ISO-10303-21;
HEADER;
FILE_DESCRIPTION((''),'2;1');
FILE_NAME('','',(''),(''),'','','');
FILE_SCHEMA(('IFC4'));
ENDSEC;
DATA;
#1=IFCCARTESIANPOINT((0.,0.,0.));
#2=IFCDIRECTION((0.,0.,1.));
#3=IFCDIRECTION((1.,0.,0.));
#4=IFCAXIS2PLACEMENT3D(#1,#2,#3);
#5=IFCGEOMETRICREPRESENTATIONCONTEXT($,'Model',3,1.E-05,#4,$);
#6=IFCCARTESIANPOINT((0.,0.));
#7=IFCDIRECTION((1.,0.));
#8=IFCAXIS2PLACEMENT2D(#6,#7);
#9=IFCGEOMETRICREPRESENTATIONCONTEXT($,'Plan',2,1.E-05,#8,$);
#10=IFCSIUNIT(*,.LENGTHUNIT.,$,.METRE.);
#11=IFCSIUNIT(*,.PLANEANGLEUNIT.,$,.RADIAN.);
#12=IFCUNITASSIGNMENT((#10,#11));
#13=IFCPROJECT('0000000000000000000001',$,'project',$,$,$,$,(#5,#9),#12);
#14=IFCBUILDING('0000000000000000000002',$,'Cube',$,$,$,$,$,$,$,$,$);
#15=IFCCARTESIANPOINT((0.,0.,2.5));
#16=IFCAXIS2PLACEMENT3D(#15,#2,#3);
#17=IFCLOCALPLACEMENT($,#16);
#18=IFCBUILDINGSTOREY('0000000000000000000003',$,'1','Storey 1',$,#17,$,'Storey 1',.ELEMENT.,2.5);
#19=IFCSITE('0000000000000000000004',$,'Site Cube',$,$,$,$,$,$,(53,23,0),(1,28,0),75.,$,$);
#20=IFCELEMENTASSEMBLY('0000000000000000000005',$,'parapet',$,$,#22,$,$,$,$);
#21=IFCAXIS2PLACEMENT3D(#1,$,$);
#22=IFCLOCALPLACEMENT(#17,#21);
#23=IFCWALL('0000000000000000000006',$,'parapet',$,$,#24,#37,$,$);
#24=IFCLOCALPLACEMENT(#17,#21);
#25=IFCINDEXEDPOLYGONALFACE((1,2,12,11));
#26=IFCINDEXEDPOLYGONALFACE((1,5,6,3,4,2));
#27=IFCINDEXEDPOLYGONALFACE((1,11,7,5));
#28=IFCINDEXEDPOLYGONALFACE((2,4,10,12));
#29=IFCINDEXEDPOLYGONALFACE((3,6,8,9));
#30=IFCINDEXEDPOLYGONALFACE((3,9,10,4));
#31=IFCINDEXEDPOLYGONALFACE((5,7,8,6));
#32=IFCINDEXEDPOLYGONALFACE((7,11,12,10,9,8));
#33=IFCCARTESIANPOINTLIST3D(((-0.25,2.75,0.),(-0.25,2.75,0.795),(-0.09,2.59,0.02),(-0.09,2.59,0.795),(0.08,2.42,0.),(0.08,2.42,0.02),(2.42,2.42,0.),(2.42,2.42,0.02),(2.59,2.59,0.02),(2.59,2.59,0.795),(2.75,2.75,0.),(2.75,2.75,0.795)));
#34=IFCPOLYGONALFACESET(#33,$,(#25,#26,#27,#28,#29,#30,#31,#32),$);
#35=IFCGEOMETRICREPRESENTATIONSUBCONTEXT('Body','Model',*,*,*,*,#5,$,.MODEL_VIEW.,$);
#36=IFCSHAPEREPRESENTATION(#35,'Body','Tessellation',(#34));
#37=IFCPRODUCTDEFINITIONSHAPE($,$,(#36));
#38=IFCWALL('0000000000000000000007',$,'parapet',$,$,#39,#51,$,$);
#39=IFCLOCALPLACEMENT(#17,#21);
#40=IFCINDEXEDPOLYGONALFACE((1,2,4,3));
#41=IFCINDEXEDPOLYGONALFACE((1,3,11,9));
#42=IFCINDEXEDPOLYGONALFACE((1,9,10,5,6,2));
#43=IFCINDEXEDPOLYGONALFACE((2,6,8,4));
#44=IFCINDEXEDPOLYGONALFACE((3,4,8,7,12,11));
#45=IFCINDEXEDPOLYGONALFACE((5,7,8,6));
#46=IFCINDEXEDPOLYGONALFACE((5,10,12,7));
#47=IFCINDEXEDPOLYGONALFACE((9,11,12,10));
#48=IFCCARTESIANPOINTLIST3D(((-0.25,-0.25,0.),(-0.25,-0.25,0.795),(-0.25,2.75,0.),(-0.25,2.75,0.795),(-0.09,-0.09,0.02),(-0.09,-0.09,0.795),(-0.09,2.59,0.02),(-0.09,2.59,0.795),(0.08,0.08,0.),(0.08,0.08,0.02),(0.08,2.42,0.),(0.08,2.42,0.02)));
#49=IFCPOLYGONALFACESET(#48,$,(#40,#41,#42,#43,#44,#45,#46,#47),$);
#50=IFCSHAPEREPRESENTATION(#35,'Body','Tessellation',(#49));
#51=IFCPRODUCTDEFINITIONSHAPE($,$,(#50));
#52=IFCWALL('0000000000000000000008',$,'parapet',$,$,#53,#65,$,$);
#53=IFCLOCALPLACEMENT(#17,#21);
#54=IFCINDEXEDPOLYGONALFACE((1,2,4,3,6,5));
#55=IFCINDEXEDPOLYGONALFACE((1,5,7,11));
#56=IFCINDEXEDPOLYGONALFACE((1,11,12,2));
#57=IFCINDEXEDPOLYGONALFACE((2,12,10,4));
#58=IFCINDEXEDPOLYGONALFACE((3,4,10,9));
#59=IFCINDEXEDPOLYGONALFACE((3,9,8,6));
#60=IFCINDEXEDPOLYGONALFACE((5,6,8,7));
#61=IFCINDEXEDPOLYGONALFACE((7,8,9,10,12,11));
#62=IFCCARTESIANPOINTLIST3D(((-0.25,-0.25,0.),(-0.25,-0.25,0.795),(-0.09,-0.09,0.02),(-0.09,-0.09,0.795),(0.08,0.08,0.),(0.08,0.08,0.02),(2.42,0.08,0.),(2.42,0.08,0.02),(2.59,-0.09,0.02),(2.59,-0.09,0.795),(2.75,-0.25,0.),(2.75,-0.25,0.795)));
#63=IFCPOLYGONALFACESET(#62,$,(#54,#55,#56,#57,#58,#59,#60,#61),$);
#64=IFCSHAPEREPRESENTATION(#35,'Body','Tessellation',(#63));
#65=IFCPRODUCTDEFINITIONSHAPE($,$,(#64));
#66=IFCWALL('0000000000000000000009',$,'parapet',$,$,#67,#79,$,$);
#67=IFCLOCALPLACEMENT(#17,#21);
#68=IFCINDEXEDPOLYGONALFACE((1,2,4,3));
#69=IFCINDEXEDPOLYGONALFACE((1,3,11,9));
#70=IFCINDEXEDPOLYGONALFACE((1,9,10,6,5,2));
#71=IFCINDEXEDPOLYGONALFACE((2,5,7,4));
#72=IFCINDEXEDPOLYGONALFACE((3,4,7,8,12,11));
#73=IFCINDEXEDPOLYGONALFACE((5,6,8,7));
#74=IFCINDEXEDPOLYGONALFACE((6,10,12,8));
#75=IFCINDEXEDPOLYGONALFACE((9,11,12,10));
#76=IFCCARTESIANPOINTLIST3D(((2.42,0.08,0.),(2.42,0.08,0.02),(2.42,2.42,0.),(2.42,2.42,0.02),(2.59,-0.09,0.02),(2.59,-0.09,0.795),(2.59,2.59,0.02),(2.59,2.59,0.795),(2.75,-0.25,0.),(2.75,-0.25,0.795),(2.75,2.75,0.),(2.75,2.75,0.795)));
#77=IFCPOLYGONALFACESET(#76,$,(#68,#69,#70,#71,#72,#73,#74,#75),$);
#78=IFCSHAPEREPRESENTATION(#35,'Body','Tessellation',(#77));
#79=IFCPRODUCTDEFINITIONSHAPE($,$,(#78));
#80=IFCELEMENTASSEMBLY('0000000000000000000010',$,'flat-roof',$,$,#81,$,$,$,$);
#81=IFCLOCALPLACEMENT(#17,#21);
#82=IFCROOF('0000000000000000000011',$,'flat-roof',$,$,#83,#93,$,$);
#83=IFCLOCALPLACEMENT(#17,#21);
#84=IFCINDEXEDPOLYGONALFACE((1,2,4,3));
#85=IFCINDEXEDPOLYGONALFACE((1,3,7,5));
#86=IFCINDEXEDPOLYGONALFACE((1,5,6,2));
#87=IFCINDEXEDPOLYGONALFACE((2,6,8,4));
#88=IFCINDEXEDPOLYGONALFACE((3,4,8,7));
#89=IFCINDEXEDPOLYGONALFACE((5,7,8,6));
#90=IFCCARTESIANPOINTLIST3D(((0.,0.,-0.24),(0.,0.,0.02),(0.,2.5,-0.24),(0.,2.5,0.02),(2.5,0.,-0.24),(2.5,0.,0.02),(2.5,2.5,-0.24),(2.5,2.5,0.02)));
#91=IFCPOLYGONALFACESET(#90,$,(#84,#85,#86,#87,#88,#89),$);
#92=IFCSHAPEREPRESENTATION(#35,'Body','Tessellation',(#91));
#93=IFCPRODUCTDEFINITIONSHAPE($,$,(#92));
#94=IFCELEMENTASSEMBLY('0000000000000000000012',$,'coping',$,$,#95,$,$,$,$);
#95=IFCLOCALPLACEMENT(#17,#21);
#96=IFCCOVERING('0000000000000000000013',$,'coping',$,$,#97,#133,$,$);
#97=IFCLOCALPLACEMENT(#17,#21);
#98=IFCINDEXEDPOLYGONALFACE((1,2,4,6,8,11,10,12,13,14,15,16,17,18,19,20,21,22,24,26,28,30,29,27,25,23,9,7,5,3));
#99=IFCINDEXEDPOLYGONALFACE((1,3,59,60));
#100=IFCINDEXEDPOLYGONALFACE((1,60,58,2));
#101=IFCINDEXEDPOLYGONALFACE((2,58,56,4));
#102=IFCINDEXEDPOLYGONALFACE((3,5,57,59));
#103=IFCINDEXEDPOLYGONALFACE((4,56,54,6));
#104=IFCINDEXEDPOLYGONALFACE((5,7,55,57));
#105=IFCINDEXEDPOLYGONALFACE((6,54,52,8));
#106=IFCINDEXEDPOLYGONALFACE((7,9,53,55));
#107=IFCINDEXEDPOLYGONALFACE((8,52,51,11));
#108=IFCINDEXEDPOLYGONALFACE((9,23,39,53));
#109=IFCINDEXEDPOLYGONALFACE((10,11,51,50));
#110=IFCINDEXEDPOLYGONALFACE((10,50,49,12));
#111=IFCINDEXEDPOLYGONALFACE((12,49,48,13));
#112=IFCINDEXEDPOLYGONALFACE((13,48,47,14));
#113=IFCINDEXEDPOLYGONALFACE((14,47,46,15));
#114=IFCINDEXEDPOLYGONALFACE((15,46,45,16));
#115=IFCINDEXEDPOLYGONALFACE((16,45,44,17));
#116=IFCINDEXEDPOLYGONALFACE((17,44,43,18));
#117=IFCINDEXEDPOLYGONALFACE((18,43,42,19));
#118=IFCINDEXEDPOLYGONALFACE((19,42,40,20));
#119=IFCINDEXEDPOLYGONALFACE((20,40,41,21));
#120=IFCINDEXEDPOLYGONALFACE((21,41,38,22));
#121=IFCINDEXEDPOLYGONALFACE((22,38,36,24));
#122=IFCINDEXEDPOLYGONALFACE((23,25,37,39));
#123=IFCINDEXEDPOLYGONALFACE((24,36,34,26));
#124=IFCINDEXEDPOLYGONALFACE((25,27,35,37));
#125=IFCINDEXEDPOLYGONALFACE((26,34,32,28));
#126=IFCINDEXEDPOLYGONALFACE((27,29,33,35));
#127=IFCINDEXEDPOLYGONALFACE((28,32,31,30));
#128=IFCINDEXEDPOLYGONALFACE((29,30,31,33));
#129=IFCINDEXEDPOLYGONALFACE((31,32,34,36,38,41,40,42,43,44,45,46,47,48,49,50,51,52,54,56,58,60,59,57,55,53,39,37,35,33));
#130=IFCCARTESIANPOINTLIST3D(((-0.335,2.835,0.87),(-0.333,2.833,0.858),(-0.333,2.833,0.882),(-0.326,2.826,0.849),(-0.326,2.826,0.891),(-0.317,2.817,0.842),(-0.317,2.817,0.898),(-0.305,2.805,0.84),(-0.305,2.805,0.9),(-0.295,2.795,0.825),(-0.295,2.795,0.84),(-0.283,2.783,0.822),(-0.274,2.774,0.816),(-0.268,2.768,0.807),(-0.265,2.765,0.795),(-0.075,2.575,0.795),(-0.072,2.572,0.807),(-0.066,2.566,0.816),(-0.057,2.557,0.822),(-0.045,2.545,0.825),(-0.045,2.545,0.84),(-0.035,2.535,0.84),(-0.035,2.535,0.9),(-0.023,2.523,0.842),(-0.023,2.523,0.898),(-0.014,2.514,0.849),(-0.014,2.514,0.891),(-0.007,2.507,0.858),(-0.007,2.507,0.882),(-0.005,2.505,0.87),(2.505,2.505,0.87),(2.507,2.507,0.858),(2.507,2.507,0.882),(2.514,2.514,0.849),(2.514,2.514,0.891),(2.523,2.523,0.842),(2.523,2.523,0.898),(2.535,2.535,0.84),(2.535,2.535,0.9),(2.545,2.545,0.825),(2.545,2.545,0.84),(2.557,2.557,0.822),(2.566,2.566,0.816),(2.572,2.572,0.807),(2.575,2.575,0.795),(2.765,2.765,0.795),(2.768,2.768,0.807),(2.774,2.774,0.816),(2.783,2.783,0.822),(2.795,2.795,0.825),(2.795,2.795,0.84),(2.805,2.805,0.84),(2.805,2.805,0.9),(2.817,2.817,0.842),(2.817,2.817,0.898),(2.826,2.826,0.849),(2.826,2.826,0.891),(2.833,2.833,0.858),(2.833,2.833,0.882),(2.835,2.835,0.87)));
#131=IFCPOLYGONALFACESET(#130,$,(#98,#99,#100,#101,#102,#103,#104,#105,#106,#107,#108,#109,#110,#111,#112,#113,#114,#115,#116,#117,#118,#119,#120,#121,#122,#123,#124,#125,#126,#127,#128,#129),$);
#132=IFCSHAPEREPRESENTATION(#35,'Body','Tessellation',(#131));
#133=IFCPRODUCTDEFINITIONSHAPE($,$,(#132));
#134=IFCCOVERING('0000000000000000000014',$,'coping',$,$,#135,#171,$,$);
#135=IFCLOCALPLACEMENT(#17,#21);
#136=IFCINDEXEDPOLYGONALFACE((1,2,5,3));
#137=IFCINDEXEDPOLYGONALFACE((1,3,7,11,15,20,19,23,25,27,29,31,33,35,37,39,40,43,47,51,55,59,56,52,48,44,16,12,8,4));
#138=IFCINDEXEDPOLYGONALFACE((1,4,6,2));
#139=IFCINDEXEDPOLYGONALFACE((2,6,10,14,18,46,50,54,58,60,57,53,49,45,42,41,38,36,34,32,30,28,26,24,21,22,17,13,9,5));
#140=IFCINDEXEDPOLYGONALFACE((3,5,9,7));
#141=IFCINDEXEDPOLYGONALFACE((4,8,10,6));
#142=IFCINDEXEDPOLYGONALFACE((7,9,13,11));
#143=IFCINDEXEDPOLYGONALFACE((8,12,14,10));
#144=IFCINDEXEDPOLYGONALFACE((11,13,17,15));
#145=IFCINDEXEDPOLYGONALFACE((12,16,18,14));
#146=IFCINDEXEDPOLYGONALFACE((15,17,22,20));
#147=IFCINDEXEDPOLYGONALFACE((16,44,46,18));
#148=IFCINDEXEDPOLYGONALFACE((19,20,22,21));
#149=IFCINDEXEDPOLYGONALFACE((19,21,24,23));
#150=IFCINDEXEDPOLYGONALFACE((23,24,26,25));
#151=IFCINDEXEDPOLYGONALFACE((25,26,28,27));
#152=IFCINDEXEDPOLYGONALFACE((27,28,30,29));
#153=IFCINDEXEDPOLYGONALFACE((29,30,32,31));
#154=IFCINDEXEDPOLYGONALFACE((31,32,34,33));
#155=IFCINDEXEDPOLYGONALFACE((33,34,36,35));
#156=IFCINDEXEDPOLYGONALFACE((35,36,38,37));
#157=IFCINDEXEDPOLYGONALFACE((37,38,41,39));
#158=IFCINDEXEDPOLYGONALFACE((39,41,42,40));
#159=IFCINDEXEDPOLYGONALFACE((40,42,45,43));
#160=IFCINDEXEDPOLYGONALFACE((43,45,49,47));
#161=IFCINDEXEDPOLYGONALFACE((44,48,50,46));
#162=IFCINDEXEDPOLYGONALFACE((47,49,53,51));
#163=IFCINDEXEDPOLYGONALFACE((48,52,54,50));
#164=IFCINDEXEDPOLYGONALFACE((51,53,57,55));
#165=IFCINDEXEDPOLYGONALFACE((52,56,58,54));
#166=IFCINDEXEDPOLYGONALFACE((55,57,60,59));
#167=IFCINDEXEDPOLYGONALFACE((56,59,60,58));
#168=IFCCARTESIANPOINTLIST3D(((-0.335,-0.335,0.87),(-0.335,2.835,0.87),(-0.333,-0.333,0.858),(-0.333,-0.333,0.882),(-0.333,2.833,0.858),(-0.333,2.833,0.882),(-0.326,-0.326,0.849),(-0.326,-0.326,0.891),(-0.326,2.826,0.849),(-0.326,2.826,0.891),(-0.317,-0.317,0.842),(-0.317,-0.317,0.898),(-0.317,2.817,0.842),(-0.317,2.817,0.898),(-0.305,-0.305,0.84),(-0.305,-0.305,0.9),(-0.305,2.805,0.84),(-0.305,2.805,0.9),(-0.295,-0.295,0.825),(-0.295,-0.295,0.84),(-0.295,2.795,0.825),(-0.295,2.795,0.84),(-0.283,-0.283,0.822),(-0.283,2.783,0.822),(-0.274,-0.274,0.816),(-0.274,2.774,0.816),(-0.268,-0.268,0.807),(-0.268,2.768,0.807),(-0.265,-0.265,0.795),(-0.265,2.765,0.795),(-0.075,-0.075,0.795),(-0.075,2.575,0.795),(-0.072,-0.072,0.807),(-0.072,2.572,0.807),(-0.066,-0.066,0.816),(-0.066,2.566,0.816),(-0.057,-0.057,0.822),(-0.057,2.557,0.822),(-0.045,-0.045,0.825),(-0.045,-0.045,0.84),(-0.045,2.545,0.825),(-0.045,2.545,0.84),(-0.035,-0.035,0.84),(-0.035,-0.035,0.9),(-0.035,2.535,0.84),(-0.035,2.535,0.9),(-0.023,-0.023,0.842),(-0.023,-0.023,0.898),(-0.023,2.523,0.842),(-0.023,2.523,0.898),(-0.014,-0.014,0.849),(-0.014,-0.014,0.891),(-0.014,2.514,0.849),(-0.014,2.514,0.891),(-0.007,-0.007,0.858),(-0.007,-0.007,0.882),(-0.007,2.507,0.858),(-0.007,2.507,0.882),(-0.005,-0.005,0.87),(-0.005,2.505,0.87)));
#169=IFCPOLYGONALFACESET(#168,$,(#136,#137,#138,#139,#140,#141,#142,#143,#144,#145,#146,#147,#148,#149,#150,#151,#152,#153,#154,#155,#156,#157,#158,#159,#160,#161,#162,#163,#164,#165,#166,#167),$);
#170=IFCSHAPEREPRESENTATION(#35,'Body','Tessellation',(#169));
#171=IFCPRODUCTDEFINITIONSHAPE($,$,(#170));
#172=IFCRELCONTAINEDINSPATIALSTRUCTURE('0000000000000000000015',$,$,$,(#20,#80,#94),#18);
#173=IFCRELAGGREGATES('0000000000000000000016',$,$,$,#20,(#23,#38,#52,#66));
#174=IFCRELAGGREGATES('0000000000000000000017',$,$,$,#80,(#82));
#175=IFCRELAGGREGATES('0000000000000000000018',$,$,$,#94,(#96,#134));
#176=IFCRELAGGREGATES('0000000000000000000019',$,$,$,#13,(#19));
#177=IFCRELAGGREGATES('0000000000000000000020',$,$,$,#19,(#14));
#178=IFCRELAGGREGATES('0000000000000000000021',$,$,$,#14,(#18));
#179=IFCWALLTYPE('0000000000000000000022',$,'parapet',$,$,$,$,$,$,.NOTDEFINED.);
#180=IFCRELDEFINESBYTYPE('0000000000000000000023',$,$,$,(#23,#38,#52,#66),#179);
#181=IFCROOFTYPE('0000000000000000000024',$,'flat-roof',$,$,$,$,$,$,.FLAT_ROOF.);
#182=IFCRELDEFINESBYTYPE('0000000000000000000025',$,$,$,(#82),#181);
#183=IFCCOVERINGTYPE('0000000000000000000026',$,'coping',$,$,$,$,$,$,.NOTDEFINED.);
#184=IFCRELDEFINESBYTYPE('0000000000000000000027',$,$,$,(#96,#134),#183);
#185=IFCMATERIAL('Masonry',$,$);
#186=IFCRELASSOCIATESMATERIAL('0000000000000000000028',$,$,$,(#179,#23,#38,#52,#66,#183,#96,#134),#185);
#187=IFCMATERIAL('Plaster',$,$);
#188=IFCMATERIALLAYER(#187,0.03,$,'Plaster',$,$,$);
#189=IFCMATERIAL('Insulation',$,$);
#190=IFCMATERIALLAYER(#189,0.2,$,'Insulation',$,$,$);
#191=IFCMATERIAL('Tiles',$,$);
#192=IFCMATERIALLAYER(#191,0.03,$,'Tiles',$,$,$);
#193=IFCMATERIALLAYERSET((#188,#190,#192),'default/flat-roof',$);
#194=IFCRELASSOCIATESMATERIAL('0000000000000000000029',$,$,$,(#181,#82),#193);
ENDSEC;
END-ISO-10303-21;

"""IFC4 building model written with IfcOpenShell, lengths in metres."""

from ifc_helpers import new_model, si_unit, frame, origin, origin_with_axes, origin_2d_with_axis, place, context, subcontext, project, spatial, polyline, outline, extrude, clip, halfspace, material, layer, layer_set, layer_usage, material_profile, profile_set, profile_usage, type_object, element, aggregate, save


model = new_model("IFC4")

# Units and contexts
model_context = context("Model", 3, precision=1e-05, world=origin_with_axes())
plan_context = context("Plan", 2, precision=1e-05, world=origin_2d_with_axis())
body_context = subcontext(model_context, "Body", "Model", "MODEL_VIEW")
ifc_project = project(units=[si_unit("LENGTHUNIT", "METRE"), si_unit("PLANEANGLEUNIT", "RADIAN")], contexts=[model_context, plan_context])

# Site, building, storey
site = spatial("IfcSite", under=ifc_project, Name="Site Cube", RefLatitude=(53, 23, 0), RefLongitude=(1, 28, 0), RefElevation=75.0)
building = spatial("IfcBuilding", under=site, Name="Cube")
storey_placement = place(None, frame((0.0, 0.0, 2.5), z_axis=(0.0, 0.0, 1.0), x_axis=(1.0, 0.0, 0.0)))
storey = spatial("IfcBuildingStorey", under=building, at=storey_placement, Name="1", Description="Storey 1", LongName="Storey 1", CompositionType="ELEMENT", Elevation=2.5)

# Element assembly, walls
assembly_1_placement = place(storey_placement, frame((0.0, 0.0, -2.5), z_axis=(0.0, 0.0, 1.0), x_axis=(1.0, 0.0, 0.0)))
assembly_1 = element("IfcElementAssembly", 1, at=assembly_1_placement, inside=storey, Name="parapet")
ifc_material_1 = material(Name="Masonry")
ifc_material_profile_1 = material_profile(ifc_material_1, outline(polyline([(0.25, 0.0), (0.25, 0.795), (0.09, 0.795), (0.09, 0.02), (-0.08, 0.02), (-0.08, 0.0), (0.25, 0.0)])))
ifc_profile_set_1 = profile_set([ifc_material_profile_1])
ifc_profile_usage_1 = profile_usage(ifc_profile_set_1)
wall_type = type_object("IfcWallType", Name="parapet", PredefinedType="NOTDEFINED", material=ifc_profile_set_1)
wall_1_placement = place(assembly_1_placement, frame((-1.0, 2.5, 2.5), z_axis=(1.0, 0.0, 0.0), x_axis=(0.0, 1.0, 0.0)))
wall_1 = element("IfcWall", 2, at=wall_1_placement, type_object=wall_type, material=ifc_profile_usage_1, Name="parapet", context=body_context, shape_type="Clipping", body=[
    clip(clip(extrude(outline(polyline([(0.25, 0.0), (0.25, 0.795), (0.09, 0.795), (0.09, 0.02), (-0.08, 0.02), (-0.08, 0.0), (0.25, 0.0)])), origin_with_axes(), (0.0, 0.0, 1.0), 4.5), halfspace(frame((0.0, -2.5, 1.0), z_axis=(-0.707107, 0.0, -0.707107), x_axis=(0.707107, 0.0, -0.707107)), False)), halfspace(frame((0.0, -2.5, 3.5), z_axis=(-0.707107, 0.0, 0.707107), x_axis=(0.707107, 0.0, 0.707107)), False)),
])
ifc_profile_usage_2 = profile_usage(ifc_profile_set_1)
wall_2_placement = place(assembly_1_placement, frame((0.0, -1.0, 2.5), z_axis=(0.0, 1.0, 0.0), x_axis=(-1.0, 0.0, 0.0)))
wall_2 = element("IfcWall", 3, at=wall_2_placement, type_object=wall_type, material=ifc_profile_usage_2, Name="parapet", context=body_context, shape_type="Clipping", body=[
    clip(clip(extrude(outline(polyline([(0.25, 0.0), (0.25, 0.795), (0.09, 0.795), (0.09, 0.02), (-0.08, 0.02), (-0.08, 0.0), (0.25, 0.0)])), origin_with_axes(), (0.0, 0.0, 1.0), 4.5), halfspace(frame((0.0, -2.5, 1.0), z_axis=(-0.707107, 0.0, -0.707107), x_axis=(0.707107, 0.0, -0.707107)), False)), halfspace(frame((0.0, -2.5, 3.5), z_axis=(-0.707107, 0.0, 0.707107), x_axis=(0.707107, 0.0, 0.707107)), False)),
])
ifc_profile_usage_3 = profile_usage(ifc_profile_set_1)
wall_3_placement = place(assembly_1_placement, frame((3.5, 0.0, 2.5), z_axis=(-1.0, 0.0, 0.0), x_axis=(0.0, -1.0, 0.0)))
wall_3 = element("IfcWall", 4, at=wall_3_placement, type_object=wall_type, material=ifc_profile_usage_3, Name="parapet", context=body_context, shape_type="Clipping", body=[
    clip(clip(extrude(outline(polyline([(0.25, 0.0), (0.25, 0.795), (0.09, 0.795), (0.09, 0.02), (-0.08, 0.02), (-0.08, 0.0), (0.25, 0.0)])), origin_with_axes(), (0.0, 0.0, 1.0), 4.5), halfspace(frame((0.0, -2.5, 1.0), z_axis=(-0.707107, 0.0, -0.707107), x_axis=(0.707107, 0.0, -0.707107)), False)), halfspace(frame((0.0, -2.5, 3.5), z_axis=(-0.707107, 0.0, 0.707107), x_axis=(0.707107, 0.0, 0.707107)), False)),
])
ifc_profile_usage_4 = profile_usage(ifc_profile_set_1)
wall_4_placement = place(assembly_1_placement, frame((2.5, 3.5, 2.5), z_axis=(0.0, -1.0, 0.0), x_axis=(1.0, 0.0, 0.0)))
wall_4 = element("IfcWall", 5, at=wall_4_placement, type_object=wall_type, material=ifc_profile_usage_4, Name="parapet", context=body_context, shape_type="Clipping", body=[
    clip(clip(extrude(outline(polyline([(0.25, 0.0), (0.25, 0.795), (0.09, 0.795), (0.09, 0.02), (-0.08, 0.02), (-0.08, 0.0), (0.25, 0.0)])), origin_with_axes(), (0.0, 0.0, 1.0), 4.5), halfspace(frame((0.0, -2.5, 1.0), z_axis=(-0.707107, 0.0, -0.707107), x_axis=(0.707107, 0.0, -0.707107)), False)), halfspace(frame((0.0, -2.5, 3.5), z_axis=(-0.707107, 0.0, 0.707107), x_axis=(0.707107, 0.0, 0.707107)), False)),
])
aggregate(assembly_1, [wall_1, wall_2, wall_3, wall_4])

# Element assembly, roof
assembly_2_placement = place(storey_placement, frame((0.0, 0.0, -2.5), z_axis=(0.0, 0.0, 1.0), x_axis=(1.0, 0.0, 0.0)))
assembly_2 = element("IfcElementAssembly", 6, at=assembly_2_placement, inside=storey, Name="flat-roof")
ifc_material_2 = material(Name="Plaster")
ifc_layer_1 = layer(ifc_material_2, 0.03, Name="Plaster")
ifc_material_3 = material(Name="Insulation")
ifc_layer_2 = layer(ifc_material_3, 0.2, Name="Insulation")
ifc_material_4 = material(Name="Tiles")
ifc_layer_3 = layer(ifc_material_4, 0.03, Name="Tiles")
ifc_layer_set = layer_set([ifc_layer_1, ifc_layer_2, ifc_layer_3], Name="default/flat-roof")
ifc_layer_usage = layer_usage(ifc_layer_set, "AXIS3", "POSITIVE", 0.0)
roof_type = type_object("IfcRoofType", Name="flat-roof", PredefinedType="FLAT_ROOF", material=ifc_layer_set)
roof_placement = place(assembly_2_placement, frame((2.5, 2.5, 2.26), z_axis=(0.0, 0.0, 1.0), x_axis=(1.0, 0.0, 0.0)))
roof = element("IfcRoof", 7, at=roof_placement, type_object=roof_type, material=ifc_layer_usage, Name="flat-roof", context=body_context, shape_type="SweptSolid", body=[
    extrude(outline(polyline([(0.0, 0.0), (-2.5, 0.0), (-2.5, -2.5), (0.0, -2.5), (0.0, 0.0)])), origin(), (0.0, 0.0, 1.0), 0.26),
])
aggregate(assembly_2, [roof])

# Element assembly, coverings
assembly_3_placement = place(storey_placement, frame((0.0, 0.0, -2.5), z_axis=(0.0, 0.0, 1.0), x_axis=(1.0, 0.0, 0.0)))
assembly_3 = element("IfcElementAssembly", 8, at=assembly_3_placement, inside=storey, Name="coping")
ifc_material_profile_2 = material_profile(ifc_material_1, outline(polyline([(0.265, 0.795), (0.268, 0.807), (0.274, 0.816), (0.283, 0.822), (0.295, 0.825), (0.295, 0.84), (0.305, 0.84), (0.317, 0.842), (0.326, 0.849), (0.333, 0.858), (0.335, 0.87), (0.333, 0.882), (0.326, 0.891), (0.317, 0.898), (0.305, 0.9), (0.035, 0.9), (0.023, 0.898), (0.014, 0.891), (0.007, 0.882), (0.005, 0.87), (0.007, 0.858), (0.014, 0.849), (0.023, 0.842), (0.035, 0.84), (0.045, 0.84), (0.045, 0.825), (0.057, 0.822), (0.066, 0.816), (0.072, 0.807), (0.075, 0.795), (0.265, 0.795)])))
ifc_profile_set_2 = profile_set([ifc_material_profile_2])
ifc_profile_usage_5 = profile_usage(ifc_profile_set_2)
covering_type_1 = type_object("IfcCoveringType", Name="coping", PredefinedType="NOTDEFINED", material=ifc_profile_set_2)
covering_1_placement = place(assembly_3_placement, frame((-1.0, 2.5, 2.5), z_axis=(1.0, 0.0, 0.0), x_axis=(0.0, 1.0, 0.0)))
covering_1 = element("IfcCovering", 9, at=covering_1_placement, type_object=covering_type_1, material=ifc_profile_usage_5, Name="coping", context=body_context, shape_type="Clipping", body=[
    clip(clip(extrude(outline(polyline([(0.265, 0.795), (0.268, 0.807), (0.274, 0.816), (0.283, 0.822), (0.295, 0.825), (0.295, 0.84), (0.305, 0.84), (0.317, 0.842), (0.326, 0.849), (0.333, 0.858), (0.335, 0.87), (0.333, 0.882), (0.326, 0.891), (0.317, 0.898), (0.305, 0.9), (0.035, 0.9), (0.023, 0.898), (0.014, 0.891), (0.007, 0.882), (0.005, 0.87), (0.007, 0.858), (0.014, 0.849), (0.023, 0.842), (0.035, 0.84), (0.045, 0.84), (0.045, 0.825), (0.057, 0.822), (0.066, 0.816), (0.072, 0.807), (0.075, 0.795), (0.265, 0.795)])), origin_with_axes(), (0.0, 0.0, 1.0), 4.5), halfspace(frame((0.0, -2.5, 1.0), z_axis=(-0.707107, 0.0, -0.707107), x_axis=(0.707107, 0.0, -0.707107)), False)), halfspace(frame((0.0, -2.5, 3.5), z_axis=(-0.707107, 0.0, 0.707107), x_axis=(0.707107, 0.0, 0.707107)), False)),
])
ifc_profile_usage_6 = profile_usage(ifc_profile_set_2)
covering_2_placement = place(assembly_3_placement, frame((0.0, -1.0, 2.5), z_axis=(0.0, 1.0, 0.0), x_axis=(-1.0, 0.0, 0.0)))
covering_2 = element("IfcCovering", 10, at=covering_2_placement, type_object=covering_type_1, material=ifc_profile_usage_6, Name="coping", context=body_context, shape_type="Clipping", body=[
    clip(clip(extrude(outline(polyline([(0.265, 0.795), (0.268, 0.807), (0.274, 0.816), (0.283, 0.822), (0.295, 0.825), (0.295, 0.84), (0.305, 0.84), (0.317, 0.842), (0.326, 0.849), (0.333, 0.858), (0.335, 0.87), (0.333, 0.882), (0.326, 0.891), (0.317, 0.898), (0.305, 0.9), (0.035, 0.9), (0.023, 0.898), (0.014, 0.891), (0.007, 0.882), (0.005, 0.87), (0.007, 0.858), (0.014, 0.849), (0.023, 0.842), (0.035, 0.84), (0.045, 0.84), (0.045, 0.825), (0.057, 0.822), (0.066, 0.816), (0.072, 0.807), (0.075, 0.795), (0.265, 0.795)])), origin_with_axes(), (0.0, 0.0, 1.0), 4.5), halfspace(frame((0.0, -2.5, 1.0), z_axis=(-0.707107, 0.0, -0.707107), x_axis=(0.707107, 0.0, -0.707107)), False)), halfspace(frame((0.0, -2.5, 3.5), z_axis=(-0.707107, 0.0, 0.707107), x_axis=(0.707107, 0.0, 0.707107)), False)),
])
aggregate(assembly_3, [covering_1, covering_2])

save(model, "model.ifc")
